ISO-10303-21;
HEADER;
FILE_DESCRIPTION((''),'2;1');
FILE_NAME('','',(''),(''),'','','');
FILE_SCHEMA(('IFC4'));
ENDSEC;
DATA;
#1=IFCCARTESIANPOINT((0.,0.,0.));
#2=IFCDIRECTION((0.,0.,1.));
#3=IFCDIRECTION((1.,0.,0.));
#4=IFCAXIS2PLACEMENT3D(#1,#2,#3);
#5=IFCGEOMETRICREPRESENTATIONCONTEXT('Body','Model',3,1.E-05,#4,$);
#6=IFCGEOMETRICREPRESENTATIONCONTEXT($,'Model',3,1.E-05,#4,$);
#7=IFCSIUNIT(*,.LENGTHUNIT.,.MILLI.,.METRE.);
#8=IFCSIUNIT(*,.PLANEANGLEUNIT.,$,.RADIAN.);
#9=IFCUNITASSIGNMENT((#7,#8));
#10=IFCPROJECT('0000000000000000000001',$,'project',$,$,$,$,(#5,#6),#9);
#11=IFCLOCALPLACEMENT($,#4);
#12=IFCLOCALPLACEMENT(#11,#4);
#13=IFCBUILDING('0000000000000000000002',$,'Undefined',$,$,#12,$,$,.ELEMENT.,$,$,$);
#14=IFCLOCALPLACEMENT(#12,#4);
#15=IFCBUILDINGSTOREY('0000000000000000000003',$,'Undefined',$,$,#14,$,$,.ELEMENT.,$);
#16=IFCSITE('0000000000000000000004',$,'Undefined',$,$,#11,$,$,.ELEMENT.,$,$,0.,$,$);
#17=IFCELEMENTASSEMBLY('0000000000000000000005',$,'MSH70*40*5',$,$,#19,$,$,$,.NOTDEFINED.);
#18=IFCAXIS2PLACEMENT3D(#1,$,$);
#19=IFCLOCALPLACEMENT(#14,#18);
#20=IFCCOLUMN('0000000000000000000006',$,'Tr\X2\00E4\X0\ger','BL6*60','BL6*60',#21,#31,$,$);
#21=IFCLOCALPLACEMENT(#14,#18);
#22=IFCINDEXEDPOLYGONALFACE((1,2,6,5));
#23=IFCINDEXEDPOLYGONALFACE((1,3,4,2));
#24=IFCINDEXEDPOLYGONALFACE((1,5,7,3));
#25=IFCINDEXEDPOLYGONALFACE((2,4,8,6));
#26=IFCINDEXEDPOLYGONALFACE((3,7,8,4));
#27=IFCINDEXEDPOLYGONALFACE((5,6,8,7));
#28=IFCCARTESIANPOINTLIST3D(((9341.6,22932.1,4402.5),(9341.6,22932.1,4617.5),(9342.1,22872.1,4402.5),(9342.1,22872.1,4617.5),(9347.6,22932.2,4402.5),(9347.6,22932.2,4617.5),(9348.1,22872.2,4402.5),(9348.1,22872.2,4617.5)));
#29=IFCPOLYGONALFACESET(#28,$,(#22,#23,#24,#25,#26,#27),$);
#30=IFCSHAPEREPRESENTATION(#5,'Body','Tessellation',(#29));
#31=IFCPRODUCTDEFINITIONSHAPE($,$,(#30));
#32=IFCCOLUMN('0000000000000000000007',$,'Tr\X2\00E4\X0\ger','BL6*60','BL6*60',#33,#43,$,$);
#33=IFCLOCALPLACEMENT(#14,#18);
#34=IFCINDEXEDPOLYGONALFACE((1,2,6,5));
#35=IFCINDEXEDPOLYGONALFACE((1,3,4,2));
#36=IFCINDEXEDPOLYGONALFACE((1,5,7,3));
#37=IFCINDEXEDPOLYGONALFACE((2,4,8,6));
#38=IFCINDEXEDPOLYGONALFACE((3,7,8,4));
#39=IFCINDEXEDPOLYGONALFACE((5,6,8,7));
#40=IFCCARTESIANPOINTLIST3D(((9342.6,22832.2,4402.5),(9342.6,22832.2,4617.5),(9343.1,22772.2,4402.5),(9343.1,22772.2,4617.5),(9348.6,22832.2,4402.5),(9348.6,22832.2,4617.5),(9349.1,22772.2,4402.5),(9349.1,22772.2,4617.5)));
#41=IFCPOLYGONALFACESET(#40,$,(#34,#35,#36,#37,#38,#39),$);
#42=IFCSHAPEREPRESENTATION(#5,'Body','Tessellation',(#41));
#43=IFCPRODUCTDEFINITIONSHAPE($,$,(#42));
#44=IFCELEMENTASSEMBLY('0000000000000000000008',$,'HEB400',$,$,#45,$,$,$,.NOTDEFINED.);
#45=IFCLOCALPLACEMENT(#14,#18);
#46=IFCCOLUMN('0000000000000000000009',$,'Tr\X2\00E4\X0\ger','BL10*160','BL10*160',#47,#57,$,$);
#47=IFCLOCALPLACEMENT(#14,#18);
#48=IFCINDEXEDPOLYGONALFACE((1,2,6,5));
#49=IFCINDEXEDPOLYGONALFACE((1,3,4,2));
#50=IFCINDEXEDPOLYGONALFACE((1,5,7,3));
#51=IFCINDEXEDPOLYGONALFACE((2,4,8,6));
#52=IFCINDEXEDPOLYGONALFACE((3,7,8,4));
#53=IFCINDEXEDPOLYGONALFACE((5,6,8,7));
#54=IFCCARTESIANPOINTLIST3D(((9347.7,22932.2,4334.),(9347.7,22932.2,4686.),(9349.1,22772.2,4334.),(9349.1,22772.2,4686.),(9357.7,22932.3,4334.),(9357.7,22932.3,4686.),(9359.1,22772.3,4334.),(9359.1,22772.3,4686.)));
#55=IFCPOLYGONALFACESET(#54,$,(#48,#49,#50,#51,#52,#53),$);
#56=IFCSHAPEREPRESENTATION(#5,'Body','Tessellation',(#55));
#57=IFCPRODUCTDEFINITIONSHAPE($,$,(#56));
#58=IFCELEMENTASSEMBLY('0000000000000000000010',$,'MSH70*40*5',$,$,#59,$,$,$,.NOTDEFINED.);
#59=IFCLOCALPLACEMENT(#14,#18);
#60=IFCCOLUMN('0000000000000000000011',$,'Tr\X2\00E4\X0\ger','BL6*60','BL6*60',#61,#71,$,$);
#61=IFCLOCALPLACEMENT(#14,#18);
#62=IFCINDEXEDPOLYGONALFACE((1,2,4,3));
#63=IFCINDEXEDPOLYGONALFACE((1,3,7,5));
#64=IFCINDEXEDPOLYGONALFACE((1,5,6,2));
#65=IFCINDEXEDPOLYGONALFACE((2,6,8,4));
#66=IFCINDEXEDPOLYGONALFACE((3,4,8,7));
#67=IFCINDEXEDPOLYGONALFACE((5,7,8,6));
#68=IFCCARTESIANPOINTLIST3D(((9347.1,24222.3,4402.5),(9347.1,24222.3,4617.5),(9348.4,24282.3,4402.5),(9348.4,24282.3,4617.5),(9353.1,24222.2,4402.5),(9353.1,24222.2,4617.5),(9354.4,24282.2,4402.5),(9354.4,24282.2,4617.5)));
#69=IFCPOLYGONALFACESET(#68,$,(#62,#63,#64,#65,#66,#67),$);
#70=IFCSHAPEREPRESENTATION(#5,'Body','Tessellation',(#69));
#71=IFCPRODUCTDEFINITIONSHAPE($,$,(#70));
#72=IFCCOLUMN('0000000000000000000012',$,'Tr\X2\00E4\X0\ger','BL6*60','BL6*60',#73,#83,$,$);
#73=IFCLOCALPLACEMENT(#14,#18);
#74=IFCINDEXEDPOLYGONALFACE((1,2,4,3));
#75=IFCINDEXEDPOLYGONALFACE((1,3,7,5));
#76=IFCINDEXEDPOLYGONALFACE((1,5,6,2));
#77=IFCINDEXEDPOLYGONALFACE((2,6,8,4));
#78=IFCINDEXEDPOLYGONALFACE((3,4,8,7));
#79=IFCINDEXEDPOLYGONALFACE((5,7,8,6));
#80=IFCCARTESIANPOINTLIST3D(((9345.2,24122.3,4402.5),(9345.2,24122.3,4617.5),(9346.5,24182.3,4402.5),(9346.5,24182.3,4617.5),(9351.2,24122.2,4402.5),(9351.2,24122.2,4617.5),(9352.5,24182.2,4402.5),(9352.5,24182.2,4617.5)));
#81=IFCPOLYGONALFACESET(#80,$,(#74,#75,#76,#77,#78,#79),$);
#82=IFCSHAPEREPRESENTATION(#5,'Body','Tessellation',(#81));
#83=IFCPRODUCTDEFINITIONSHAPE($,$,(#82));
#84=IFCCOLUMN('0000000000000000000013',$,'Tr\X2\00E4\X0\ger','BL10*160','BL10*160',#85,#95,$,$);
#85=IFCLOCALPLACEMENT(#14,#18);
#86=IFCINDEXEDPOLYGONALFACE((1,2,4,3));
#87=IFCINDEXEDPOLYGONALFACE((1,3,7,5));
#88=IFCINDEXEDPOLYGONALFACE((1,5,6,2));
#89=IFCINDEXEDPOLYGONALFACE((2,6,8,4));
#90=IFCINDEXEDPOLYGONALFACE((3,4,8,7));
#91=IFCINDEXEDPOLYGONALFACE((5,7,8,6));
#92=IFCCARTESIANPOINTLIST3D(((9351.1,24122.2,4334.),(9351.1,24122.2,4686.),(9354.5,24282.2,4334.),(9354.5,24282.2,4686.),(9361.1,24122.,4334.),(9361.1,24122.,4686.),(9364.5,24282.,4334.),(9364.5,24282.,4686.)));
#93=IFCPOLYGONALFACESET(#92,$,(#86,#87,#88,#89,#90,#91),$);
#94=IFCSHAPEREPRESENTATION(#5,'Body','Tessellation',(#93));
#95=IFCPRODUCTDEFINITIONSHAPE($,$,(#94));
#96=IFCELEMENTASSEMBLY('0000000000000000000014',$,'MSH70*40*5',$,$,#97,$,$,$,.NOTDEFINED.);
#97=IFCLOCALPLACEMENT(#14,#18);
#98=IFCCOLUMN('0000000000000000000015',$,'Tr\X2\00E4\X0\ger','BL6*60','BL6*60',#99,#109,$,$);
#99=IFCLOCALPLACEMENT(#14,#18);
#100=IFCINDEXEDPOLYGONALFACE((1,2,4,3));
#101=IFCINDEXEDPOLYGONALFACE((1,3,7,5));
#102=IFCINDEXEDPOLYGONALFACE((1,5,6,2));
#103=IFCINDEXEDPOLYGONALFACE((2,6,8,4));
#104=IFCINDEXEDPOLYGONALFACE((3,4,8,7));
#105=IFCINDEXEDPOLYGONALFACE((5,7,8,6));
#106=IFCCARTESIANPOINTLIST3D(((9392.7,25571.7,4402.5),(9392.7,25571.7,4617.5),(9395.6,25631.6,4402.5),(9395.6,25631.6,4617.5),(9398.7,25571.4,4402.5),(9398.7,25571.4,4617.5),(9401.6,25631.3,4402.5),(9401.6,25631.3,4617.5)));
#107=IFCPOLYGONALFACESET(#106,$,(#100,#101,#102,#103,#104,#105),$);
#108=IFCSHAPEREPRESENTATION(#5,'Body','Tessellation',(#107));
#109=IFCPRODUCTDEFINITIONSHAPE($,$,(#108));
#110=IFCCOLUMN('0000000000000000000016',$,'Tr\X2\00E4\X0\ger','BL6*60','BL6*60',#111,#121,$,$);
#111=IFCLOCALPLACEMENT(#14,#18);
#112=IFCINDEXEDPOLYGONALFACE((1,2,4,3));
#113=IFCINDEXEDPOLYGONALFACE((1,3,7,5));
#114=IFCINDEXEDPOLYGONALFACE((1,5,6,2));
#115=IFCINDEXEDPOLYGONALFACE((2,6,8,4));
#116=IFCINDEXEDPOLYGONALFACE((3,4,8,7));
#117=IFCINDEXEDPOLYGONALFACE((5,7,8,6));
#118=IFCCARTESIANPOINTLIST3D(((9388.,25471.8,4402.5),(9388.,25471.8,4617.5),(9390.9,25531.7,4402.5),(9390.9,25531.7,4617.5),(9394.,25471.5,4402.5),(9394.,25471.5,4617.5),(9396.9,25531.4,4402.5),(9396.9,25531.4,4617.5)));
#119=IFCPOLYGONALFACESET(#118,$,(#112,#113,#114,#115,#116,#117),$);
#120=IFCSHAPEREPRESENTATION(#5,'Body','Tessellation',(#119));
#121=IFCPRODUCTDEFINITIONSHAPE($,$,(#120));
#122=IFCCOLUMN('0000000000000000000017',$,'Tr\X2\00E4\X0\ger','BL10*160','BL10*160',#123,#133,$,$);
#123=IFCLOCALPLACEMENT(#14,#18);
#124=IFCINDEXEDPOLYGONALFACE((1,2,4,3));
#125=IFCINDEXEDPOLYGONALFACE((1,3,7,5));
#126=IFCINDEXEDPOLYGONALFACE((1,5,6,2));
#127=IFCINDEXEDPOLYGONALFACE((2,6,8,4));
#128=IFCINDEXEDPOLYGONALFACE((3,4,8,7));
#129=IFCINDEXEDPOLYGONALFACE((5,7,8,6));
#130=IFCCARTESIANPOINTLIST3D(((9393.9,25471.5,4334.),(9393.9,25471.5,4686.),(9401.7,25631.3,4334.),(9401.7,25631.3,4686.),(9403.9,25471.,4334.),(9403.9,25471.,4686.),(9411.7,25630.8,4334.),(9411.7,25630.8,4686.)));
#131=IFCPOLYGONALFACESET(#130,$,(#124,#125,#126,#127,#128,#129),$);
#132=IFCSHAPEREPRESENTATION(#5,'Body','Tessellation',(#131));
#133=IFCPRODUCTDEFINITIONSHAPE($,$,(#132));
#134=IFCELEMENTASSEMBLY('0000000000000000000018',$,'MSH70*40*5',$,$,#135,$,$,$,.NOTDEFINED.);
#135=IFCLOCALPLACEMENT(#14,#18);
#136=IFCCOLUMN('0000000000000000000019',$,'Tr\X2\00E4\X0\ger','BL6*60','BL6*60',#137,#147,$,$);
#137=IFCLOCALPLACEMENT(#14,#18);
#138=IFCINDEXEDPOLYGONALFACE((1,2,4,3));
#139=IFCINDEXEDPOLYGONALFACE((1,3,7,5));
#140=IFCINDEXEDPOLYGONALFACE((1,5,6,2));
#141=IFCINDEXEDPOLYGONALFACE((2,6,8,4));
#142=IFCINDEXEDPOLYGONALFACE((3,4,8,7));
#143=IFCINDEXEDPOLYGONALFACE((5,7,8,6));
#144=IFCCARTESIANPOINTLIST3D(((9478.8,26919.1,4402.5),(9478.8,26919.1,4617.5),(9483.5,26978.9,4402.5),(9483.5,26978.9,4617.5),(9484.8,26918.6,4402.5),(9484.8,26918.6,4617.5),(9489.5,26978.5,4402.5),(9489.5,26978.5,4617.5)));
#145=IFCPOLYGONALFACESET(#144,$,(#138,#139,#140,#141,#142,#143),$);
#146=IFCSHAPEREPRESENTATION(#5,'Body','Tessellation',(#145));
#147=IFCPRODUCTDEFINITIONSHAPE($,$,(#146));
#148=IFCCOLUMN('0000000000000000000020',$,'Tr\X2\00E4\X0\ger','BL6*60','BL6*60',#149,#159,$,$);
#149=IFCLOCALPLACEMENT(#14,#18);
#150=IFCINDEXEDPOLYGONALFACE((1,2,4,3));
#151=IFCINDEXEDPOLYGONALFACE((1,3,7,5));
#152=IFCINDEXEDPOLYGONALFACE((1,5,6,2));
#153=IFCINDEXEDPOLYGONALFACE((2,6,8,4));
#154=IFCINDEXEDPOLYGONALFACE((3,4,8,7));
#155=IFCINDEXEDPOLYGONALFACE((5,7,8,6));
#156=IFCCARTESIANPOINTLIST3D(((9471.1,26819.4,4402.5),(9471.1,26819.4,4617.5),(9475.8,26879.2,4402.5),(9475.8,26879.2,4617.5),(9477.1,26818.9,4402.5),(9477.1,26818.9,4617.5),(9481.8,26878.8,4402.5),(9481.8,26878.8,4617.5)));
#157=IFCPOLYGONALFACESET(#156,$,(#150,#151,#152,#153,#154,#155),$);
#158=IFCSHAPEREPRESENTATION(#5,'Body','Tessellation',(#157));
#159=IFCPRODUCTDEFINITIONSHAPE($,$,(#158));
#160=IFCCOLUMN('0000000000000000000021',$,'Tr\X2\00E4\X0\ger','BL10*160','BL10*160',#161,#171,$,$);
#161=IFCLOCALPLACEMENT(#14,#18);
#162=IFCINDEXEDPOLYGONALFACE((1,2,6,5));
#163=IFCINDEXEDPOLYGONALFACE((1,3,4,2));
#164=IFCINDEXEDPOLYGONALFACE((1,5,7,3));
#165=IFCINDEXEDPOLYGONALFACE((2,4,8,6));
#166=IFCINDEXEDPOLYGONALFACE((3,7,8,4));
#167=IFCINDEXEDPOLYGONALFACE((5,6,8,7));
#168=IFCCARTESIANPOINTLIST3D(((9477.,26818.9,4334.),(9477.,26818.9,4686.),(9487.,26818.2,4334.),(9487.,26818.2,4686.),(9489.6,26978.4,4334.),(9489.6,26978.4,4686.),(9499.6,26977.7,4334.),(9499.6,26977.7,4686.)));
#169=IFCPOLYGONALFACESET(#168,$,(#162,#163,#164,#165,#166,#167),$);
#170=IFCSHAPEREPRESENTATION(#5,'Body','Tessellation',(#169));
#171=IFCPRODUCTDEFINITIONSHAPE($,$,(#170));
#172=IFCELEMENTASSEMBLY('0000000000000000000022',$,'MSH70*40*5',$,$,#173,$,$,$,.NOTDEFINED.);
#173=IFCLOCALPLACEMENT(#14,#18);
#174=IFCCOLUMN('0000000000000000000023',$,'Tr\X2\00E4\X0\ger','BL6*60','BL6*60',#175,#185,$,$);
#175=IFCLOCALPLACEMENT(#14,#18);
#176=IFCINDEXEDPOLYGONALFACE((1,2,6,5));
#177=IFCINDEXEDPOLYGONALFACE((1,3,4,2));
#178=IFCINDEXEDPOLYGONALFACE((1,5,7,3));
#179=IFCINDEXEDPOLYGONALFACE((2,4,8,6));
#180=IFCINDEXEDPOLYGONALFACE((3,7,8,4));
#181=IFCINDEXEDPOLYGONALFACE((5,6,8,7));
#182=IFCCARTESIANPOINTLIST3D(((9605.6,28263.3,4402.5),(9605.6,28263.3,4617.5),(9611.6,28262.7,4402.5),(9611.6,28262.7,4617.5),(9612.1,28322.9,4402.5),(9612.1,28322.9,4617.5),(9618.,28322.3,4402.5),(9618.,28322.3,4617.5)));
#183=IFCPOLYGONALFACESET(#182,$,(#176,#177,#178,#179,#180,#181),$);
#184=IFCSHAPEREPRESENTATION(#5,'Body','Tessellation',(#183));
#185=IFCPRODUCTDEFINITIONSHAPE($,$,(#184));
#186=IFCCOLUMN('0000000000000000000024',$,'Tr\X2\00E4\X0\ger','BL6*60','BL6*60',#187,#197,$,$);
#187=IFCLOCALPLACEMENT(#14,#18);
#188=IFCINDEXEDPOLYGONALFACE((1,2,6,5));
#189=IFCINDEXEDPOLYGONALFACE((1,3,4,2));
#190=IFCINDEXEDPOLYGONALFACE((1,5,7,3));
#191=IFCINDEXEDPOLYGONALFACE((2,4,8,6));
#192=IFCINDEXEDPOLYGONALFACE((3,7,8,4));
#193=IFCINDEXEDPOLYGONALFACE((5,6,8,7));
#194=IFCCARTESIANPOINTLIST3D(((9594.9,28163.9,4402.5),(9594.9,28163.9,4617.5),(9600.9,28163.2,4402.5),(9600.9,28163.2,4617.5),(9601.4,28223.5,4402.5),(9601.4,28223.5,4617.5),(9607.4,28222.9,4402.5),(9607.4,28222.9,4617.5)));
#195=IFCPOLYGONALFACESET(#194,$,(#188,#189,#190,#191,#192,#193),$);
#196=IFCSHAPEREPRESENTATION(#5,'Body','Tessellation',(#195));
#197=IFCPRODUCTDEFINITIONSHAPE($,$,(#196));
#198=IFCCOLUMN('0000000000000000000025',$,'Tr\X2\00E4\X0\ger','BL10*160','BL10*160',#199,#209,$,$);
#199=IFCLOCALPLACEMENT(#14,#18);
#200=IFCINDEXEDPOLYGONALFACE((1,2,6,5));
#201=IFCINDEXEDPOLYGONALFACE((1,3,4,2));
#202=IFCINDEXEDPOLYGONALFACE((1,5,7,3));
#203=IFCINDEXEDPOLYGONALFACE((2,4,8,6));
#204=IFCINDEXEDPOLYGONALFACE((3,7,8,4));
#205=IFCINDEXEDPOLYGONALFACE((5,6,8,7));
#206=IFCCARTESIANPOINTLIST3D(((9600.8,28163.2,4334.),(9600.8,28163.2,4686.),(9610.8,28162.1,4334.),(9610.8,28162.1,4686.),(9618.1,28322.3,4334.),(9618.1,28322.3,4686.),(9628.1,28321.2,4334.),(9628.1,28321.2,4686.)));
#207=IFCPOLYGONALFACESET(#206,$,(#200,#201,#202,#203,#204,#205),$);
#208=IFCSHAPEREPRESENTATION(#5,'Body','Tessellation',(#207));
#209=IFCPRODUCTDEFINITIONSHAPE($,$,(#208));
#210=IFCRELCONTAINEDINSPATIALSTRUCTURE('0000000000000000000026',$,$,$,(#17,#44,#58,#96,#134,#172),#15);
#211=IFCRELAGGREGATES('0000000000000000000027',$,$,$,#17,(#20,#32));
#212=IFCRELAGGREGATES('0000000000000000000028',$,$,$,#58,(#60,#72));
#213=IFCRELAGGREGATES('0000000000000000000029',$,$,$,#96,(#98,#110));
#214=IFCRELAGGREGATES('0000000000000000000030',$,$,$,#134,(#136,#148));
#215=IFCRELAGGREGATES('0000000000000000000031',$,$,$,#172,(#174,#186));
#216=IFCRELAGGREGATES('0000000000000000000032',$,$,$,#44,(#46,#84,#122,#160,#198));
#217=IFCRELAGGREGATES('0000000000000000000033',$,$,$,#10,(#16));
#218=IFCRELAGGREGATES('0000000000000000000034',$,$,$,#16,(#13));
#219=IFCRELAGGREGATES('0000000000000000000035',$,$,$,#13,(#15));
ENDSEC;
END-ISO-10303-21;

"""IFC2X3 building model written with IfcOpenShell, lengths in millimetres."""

from ifc_helpers import new_model, si_unit, frame, origin_with_axes, origin_2d_with_axis, place, context, project, spatial, rectangle, extrude, element, aggregate, save


model = new_model("IFC2X3")

# Units and contexts
model_context_1 = context("Model", 3, precision=1e-05, world=origin_with_axes(), identifier="Body")
model_context_2 = context("Model", 3, precision=1e-05, world=origin_with_axes())
ifc_project = project(units=[si_unit("LENGTHUNIT", "METRE", prefix="MILLI"), si_unit("PLANEANGLEUNIT", "RADIAN")], contexts=[model_context_1, model_context_2])

# Site, building, storey
site_placement = place(None, origin_with_axes())
site = spatial("IfcSite", under=ifc_project, at=site_placement, Name="Undefined", CompositionType="ELEMENT", RefElevation=0.0)
building_placement = place(site_placement, origin_with_axes())
building = spatial("IfcBuilding", under=site, at=building_placement, Name="Undefined", CompositionType="ELEMENT")
storey_placement = place(building_placement, origin_with_axes())
storey = spatial("IfcBuildingStorey", under=building, at=storey_placement, Name="Undefined", CompositionType="ELEMENT")

# Element assembly, columns
assembly_1 = element("IfcElementAssembly", 1, inside=storey, Name="MSH70*40*5", PredefinedType="NOTDEFINED")
column_1_placement = place(storey_placement, frame((9344.9, 22902.2, 4402.5), z_axis=(0.0, 0.0, 1.0), x_axis=(1.0, 0.0, 0.0)))
column_1 = element("IfcColumn", 2, at=column_1_placement, Name="Träger", Description="BL6*60", ObjectType="BL6*60", context=model_context_1, shape_type="SweptSolid", body=[
    extrude(rectangle(XDim=6.0, YDim=60.0, at=origin_2d_with_axis()), frame((0.0, 0.0, 215.0), z_axis=(0.0, 0.0, -1.0), x_axis=(-0.999962, -0.008727, 0.0)), (0.0, 0.0, 1.0), 215.0),
])
column_2_placement = place(storey_placement, frame((9345.9, 22802.2, 4402.5), z_axis=(0.0, 0.0, 1.0), x_axis=(1.0, 0.0, 0.0)))
column_2 = element("IfcColumn", 3, at=column_2_placement, Name="Träger", Description="BL6*60", ObjectType="BL6*60", context=model_context_1, shape_type="SweptSolid", body=[
    extrude(rectangle(XDim=6.0, YDim=60.0, at=origin_2d_with_axis()), frame((0.0, 0.0, 215.0), z_axis=(0.0, 0.0, -1.0), x_axis=(-0.999962, -0.008727, 0.0)), (0.0, 0.0, 1.0), 215.0),
])

# Element assembly, column
assembly_2 = element("IfcElementAssembly", 4, inside=storey, Name="HEB400", PredefinedType="NOTDEFINED")
column_3_placement = place(storey_placement, frame((9353.4, 22852.2, 4334.0), z_axis=(0.0, 0.0, 1.0), x_axis=(1.0, 0.0, 0.0)))
column_3 = element("IfcColumn", 5, at=column_3_placement, Name="Träger", Description="BL10*160", ObjectType="BL10*160", context=model_context_1, shape_type="SweptSolid", body=[
    extrude(rectangle(XDim=10.0, YDim=160.0, at=origin_2d_with_axis()), frame((0.0, 0.0, 352.0), z_axis=(0.0, 0.0, -1.0), x_axis=(-0.999962, -0.008727, 0.0)), (0.0, 0.0, 1.0), 352.0),
])

# Element assembly, columns
assembly_3 = element("IfcElementAssembly", 6, inside=storey, Name="MSH70*40*5", PredefinedType="NOTDEFINED")
column_4_placement = place(storey_placement, frame((9350.8, 24252.2, 4402.5), z_axis=(0.0, 0.0, 1.0), x_axis=(1.0, 0.0, 0.0)))
column_4 = element("IfcColumn", 7, at=column_4_placement, Name="Träger", Description="BL6*60", ObjectType="BL6*60", context=model_context_1, shape_type="SweptSolid", body=[
    extrude(rectangle(XDim=6.0, YDim=60.0, at=origin_2d_with_axis()), frame((0.0, 0.0, 215.0), z_axis=(0.0, 0.0, -1.0), x_axis=(-0.999781, 0.020942, 0.0)), (0.0, 0.0, 1.0), 215.0),
])
column_5_placement = place(storey_placement, frame((9348.8, 24152.3, 4402.5), z_axis=(0.0, 0.0, 1.0), x_axis=(1.0, 0.0, 0.0)))
column_5 = element("IfcColumn", 8, at=column_5_placement, Name="Träger", Description="BL6*60", ObjectType="BL6*60", context=model_context_1, shape_type="SweptSolid", body=[
    extrude(rectangle(XDim=6.0, YDim=60.0, at=origin_2d_with_axis()), frame((0.0, 0.0, 215.0), z_axis=(0.0, 0.0, -1.0), x_axis=(-0.999781, 0.020942, 0.0)), (0.0, 0.0, 1.0), 215.0),
])

# Column
column_6_placement = place(storey_placement, frame((9357.8, 24202.1, 4334.0), z_axis=(0.0, 0.0, 1.0), x_axis=(1.0, 0.0, 0.0)))
column_6 = element("IfcColumn", 9, at=column_6_placement, Name="Träger", Description="BL10*160", ObjectType="BL10*160", context=model_context_1, shape_type="SweptSolid", body=[
    extrude(rectangle(XDim=10.0, YDim=160.0, at=origin_2d_with_axis()), frame((0.0, 0.0, 352.0), z_axis=(0.0, 0.0, -1.0), x_axis=(-0.999781, 0.020942, 0.0)), (0.0, 0.0, 1.0), 352.0),
])

# Element assembly, columns
assembly_4 = element("IfcElementAssembly", 10, inside=storey, Name="MSH70*40*5", PredefinedType="NOTDEFINED")
column_7_placement = place(storey_placement, frame((9397.2, 25601.5, 4402.5), z_axis=(0.0, 0.0, 1.0), x_axis=(1.0, 0.0, 0.0)))
column_7 = element("IfcColumn", 11, at=column_7_placement, Name="Träger", Description="BL6*60", ObjectType="BL6*60", context=model_context_1, shape_type="SweptSolid", body=[
    extrude(rectangle(XDim=6.0, YDim=60.0, at=origin_2d_with_axis()), frame((0.0, 0.0, 215.0), z_axis=(0.0, 0.0, -1.0), x_axis=(-0.998806, 0.04885, 0.0)), (0.0, 0.0, 1.0), 215.0),
])
column_8_placement = place(storey_placement, frame((9392.4, 25501.6, 4402.5), z_axis=(0.0, 0.0, 1.0), x_axis=(1.0, 0.0, 0.0)))
column_8 = element("IfcColumn", 12, at=column_8_placement, Name="Träger", Description="BL6*60", ObjectType="BL6*60", context=model_context_1, shape_type="SweptSolid", body=[
    extrude(rectangle(XDim=6.0, YDim=60.0, at=origin_2d_with_axis()), frame((0.0, 0.0, 215.0), z_axis=(0.0, 0.0, -1.0), x_axis=(-0.998806, 0.04885, 0.0)), (0.0, 0.0, 1.0), 215.0),
])

# Column
column_9_placement = place(storey_placement, frame((9402.8, 25551.2, 4334.0), z_axis=(0.0, 0.0, 1.0), x_axis=(1.0, 0.0, 0.0)))
column_9 = element("IfcColumn", 13, at=column_9_placement, Name="Träger", Description="BL10*160", ObjectType="BL10*160", context=model_context_1, shape_type="SweptSolid", body=[
    extrude(rectangle(XDim=10.0, YDim=160.0, at=origin_2d_with_axis()), frame((0.0, 0.0, 352.0), z_axis=(0.0, 0.0, -1.0), x_axis=(-0.998806, 0.04885, 0.0)), (0.0, 0.0, 1.0), 352.0),
])

# Element assembly, columns
assembly_5 = element("IfcElementAssembly", 14, inside=storey, Name="MSH70*40*5", PredefinedType="NOTDEFINED")
column_10_placement = place(storey_placement, frame((9484.2, 26948.8, 4402.5), z_axis=(0.0, 0.0, 1.0), x_axis=(1.0, 0.0, 0.0)))
column_10 = element("IfcColumn", 15, at=column_10_placement, Name="Träger", Description="BL6*60", ObjectType="BL6*60", context=model_context_1, shape_type="SweptSolid", body=[
    extrude(rectangle(XDim=6.0, YDim=60.0, at=origin_2d_with_axis()), frame((0.0, 0.0, 215.0), z_axis=(0.0, 0.0, -1.0), x_axis=(-0.996917, 0.078459, 0.0)), (0.0, 0.0, 1.0), 215.0),
])
column_11_placement = place(storey_placement, frame((9476.5, 26849.1, 4402.5), z_axis=(0.0, 0.0, 1.0), x_axis=(1.0, 0.0, 0.0)))
column_11 = element("IfcColumn", 16, at=column_11_placement, Name="Träger", Description="BL6*60", ObjectType="BL6*60", context=model_context_1, shape_type="SweptSolid", body=[
    extrude(rectangle(XDim=6.0, YDim=60.0, at=origin_2d_with_axis()), frame((0.0, 0.0, 215.0), z_axis=(0.0, 0.0, -1.0), x_axis=(-0.996917, 0.078459, 0.0)), (0.0, 0.0, 1.0), 215.0),
])

# Column
column_12_placement = place(storey_placement, frame((9488.3, 26898.3, 4334.0), z_axis=(0.0, 0.0, 1.0), x_axis=(1.0, 0.0, 0.0)))
column_12 = element("IfcColumn", 17, at=column_12_placement, Name="Träger", Description="BL10*160", ObjectType="BL10*160", context=model_context_1, shape_type="SweptSolid", body=[
    extrude(rectangle(XDim=10.0, YDim=160.0, at=origin_2d_with_axis()), frame((0.0, 0.0, 352.0), z_axis=(0.0, 0.0, -1.0), x_axis=(-0.996917, 0.078459, 0.0)), (0.0, 0.0, 1.0), 352.0),
])

# Element assembly, columns
assembly_6 = element("IfcElementAssembly", 18, inside=storey, Name="MSH70*40*5", PredefinedType="NOTDEFINED")
column_13_placement = place(storey_placement, frame((9611.8, 28292.8, 4402.5), z_axis=(0.0, 0.0, 1.0), x_axis=(1.0, 0.0, 0.0)))
column_13 = element("IfcColumn", 19, at=column_13_placement, Name="Träger", Description="BL6*60", ObjectType="BL6*60", context=model_context_1, shape_type="SweptSolid", body=[
    extrude(rectangle(XDim=6.0, YDim=60.0, at=origin_2d_with_axis()), frame((0.0, 0.0, 215.0), z_axis=(0.0, 0.0, -1.0), x_axis=(-0.994151, 0.107999, 0.0)), (0.0, 0.0, 1.0), 215.0),
])
column_14_placement = place(storey_placement, frame((9601.2, 28193.4, 4402.5), z_axis=(0.0, 0.0, 1.0), x_axis=(1.0, 0.0, 0.0)))
column_14 = element("IfcColumn", 20, at=column_14_placement, Name="Träger", Description="BL6*60", ObjectType="BL6*60", context=model_context_1, shape_type="SweptSolid", body=[
    extrude(rectangle(XDim=6.0, YDim=60.0, at=origin_2d_with_axis()), frame((0.0, 0.0, 215.0), z_axis=(0.0, 0.0, -1.0), x_axis=(-0.994151, 0.107999, 0.0)), (0.0, 0.0, 1.0), 215.0),
])

# Column
column_15_placement = place(storey_placement, frame((9614.5, 28242.2, 4334.0), z_axis=(0.0, 0.0, 1.0), x_axis=(1.0, 0.0, 0.0)))
column_15 = element("IfcColumn", 21, at=column_15_placement, Name="Träger", Description="BL10*160", ObjectType="BL10*160", context=model_context_1, shape_type="SweptSolid", body=[
    extrude(rectangle(XDim=10.0, YDim=160.0, at=origin_2d_with_axis()), frame((0.0, 0.0, 352.0), z_axis=(0.0, 0.0, -1.0), x_axis=(-0.994151, 0.107999, 0.0)), (0.0, 0.0, 1.0), 352.0),
])
aggregate(assembly_1, [column_1, column_2])
aggregate(assembly_3, [column_4, column_5])
aggregate(assembly_4, [column_7, column_8])
aggregate(assembly_5, [column_10, column_11])
aggregate(assembly_6, [column_13, column_14])

aggregate(assembly_2, [column_3, column_6, column_9, column_12, column_15])

save(model, "model.ifc")
